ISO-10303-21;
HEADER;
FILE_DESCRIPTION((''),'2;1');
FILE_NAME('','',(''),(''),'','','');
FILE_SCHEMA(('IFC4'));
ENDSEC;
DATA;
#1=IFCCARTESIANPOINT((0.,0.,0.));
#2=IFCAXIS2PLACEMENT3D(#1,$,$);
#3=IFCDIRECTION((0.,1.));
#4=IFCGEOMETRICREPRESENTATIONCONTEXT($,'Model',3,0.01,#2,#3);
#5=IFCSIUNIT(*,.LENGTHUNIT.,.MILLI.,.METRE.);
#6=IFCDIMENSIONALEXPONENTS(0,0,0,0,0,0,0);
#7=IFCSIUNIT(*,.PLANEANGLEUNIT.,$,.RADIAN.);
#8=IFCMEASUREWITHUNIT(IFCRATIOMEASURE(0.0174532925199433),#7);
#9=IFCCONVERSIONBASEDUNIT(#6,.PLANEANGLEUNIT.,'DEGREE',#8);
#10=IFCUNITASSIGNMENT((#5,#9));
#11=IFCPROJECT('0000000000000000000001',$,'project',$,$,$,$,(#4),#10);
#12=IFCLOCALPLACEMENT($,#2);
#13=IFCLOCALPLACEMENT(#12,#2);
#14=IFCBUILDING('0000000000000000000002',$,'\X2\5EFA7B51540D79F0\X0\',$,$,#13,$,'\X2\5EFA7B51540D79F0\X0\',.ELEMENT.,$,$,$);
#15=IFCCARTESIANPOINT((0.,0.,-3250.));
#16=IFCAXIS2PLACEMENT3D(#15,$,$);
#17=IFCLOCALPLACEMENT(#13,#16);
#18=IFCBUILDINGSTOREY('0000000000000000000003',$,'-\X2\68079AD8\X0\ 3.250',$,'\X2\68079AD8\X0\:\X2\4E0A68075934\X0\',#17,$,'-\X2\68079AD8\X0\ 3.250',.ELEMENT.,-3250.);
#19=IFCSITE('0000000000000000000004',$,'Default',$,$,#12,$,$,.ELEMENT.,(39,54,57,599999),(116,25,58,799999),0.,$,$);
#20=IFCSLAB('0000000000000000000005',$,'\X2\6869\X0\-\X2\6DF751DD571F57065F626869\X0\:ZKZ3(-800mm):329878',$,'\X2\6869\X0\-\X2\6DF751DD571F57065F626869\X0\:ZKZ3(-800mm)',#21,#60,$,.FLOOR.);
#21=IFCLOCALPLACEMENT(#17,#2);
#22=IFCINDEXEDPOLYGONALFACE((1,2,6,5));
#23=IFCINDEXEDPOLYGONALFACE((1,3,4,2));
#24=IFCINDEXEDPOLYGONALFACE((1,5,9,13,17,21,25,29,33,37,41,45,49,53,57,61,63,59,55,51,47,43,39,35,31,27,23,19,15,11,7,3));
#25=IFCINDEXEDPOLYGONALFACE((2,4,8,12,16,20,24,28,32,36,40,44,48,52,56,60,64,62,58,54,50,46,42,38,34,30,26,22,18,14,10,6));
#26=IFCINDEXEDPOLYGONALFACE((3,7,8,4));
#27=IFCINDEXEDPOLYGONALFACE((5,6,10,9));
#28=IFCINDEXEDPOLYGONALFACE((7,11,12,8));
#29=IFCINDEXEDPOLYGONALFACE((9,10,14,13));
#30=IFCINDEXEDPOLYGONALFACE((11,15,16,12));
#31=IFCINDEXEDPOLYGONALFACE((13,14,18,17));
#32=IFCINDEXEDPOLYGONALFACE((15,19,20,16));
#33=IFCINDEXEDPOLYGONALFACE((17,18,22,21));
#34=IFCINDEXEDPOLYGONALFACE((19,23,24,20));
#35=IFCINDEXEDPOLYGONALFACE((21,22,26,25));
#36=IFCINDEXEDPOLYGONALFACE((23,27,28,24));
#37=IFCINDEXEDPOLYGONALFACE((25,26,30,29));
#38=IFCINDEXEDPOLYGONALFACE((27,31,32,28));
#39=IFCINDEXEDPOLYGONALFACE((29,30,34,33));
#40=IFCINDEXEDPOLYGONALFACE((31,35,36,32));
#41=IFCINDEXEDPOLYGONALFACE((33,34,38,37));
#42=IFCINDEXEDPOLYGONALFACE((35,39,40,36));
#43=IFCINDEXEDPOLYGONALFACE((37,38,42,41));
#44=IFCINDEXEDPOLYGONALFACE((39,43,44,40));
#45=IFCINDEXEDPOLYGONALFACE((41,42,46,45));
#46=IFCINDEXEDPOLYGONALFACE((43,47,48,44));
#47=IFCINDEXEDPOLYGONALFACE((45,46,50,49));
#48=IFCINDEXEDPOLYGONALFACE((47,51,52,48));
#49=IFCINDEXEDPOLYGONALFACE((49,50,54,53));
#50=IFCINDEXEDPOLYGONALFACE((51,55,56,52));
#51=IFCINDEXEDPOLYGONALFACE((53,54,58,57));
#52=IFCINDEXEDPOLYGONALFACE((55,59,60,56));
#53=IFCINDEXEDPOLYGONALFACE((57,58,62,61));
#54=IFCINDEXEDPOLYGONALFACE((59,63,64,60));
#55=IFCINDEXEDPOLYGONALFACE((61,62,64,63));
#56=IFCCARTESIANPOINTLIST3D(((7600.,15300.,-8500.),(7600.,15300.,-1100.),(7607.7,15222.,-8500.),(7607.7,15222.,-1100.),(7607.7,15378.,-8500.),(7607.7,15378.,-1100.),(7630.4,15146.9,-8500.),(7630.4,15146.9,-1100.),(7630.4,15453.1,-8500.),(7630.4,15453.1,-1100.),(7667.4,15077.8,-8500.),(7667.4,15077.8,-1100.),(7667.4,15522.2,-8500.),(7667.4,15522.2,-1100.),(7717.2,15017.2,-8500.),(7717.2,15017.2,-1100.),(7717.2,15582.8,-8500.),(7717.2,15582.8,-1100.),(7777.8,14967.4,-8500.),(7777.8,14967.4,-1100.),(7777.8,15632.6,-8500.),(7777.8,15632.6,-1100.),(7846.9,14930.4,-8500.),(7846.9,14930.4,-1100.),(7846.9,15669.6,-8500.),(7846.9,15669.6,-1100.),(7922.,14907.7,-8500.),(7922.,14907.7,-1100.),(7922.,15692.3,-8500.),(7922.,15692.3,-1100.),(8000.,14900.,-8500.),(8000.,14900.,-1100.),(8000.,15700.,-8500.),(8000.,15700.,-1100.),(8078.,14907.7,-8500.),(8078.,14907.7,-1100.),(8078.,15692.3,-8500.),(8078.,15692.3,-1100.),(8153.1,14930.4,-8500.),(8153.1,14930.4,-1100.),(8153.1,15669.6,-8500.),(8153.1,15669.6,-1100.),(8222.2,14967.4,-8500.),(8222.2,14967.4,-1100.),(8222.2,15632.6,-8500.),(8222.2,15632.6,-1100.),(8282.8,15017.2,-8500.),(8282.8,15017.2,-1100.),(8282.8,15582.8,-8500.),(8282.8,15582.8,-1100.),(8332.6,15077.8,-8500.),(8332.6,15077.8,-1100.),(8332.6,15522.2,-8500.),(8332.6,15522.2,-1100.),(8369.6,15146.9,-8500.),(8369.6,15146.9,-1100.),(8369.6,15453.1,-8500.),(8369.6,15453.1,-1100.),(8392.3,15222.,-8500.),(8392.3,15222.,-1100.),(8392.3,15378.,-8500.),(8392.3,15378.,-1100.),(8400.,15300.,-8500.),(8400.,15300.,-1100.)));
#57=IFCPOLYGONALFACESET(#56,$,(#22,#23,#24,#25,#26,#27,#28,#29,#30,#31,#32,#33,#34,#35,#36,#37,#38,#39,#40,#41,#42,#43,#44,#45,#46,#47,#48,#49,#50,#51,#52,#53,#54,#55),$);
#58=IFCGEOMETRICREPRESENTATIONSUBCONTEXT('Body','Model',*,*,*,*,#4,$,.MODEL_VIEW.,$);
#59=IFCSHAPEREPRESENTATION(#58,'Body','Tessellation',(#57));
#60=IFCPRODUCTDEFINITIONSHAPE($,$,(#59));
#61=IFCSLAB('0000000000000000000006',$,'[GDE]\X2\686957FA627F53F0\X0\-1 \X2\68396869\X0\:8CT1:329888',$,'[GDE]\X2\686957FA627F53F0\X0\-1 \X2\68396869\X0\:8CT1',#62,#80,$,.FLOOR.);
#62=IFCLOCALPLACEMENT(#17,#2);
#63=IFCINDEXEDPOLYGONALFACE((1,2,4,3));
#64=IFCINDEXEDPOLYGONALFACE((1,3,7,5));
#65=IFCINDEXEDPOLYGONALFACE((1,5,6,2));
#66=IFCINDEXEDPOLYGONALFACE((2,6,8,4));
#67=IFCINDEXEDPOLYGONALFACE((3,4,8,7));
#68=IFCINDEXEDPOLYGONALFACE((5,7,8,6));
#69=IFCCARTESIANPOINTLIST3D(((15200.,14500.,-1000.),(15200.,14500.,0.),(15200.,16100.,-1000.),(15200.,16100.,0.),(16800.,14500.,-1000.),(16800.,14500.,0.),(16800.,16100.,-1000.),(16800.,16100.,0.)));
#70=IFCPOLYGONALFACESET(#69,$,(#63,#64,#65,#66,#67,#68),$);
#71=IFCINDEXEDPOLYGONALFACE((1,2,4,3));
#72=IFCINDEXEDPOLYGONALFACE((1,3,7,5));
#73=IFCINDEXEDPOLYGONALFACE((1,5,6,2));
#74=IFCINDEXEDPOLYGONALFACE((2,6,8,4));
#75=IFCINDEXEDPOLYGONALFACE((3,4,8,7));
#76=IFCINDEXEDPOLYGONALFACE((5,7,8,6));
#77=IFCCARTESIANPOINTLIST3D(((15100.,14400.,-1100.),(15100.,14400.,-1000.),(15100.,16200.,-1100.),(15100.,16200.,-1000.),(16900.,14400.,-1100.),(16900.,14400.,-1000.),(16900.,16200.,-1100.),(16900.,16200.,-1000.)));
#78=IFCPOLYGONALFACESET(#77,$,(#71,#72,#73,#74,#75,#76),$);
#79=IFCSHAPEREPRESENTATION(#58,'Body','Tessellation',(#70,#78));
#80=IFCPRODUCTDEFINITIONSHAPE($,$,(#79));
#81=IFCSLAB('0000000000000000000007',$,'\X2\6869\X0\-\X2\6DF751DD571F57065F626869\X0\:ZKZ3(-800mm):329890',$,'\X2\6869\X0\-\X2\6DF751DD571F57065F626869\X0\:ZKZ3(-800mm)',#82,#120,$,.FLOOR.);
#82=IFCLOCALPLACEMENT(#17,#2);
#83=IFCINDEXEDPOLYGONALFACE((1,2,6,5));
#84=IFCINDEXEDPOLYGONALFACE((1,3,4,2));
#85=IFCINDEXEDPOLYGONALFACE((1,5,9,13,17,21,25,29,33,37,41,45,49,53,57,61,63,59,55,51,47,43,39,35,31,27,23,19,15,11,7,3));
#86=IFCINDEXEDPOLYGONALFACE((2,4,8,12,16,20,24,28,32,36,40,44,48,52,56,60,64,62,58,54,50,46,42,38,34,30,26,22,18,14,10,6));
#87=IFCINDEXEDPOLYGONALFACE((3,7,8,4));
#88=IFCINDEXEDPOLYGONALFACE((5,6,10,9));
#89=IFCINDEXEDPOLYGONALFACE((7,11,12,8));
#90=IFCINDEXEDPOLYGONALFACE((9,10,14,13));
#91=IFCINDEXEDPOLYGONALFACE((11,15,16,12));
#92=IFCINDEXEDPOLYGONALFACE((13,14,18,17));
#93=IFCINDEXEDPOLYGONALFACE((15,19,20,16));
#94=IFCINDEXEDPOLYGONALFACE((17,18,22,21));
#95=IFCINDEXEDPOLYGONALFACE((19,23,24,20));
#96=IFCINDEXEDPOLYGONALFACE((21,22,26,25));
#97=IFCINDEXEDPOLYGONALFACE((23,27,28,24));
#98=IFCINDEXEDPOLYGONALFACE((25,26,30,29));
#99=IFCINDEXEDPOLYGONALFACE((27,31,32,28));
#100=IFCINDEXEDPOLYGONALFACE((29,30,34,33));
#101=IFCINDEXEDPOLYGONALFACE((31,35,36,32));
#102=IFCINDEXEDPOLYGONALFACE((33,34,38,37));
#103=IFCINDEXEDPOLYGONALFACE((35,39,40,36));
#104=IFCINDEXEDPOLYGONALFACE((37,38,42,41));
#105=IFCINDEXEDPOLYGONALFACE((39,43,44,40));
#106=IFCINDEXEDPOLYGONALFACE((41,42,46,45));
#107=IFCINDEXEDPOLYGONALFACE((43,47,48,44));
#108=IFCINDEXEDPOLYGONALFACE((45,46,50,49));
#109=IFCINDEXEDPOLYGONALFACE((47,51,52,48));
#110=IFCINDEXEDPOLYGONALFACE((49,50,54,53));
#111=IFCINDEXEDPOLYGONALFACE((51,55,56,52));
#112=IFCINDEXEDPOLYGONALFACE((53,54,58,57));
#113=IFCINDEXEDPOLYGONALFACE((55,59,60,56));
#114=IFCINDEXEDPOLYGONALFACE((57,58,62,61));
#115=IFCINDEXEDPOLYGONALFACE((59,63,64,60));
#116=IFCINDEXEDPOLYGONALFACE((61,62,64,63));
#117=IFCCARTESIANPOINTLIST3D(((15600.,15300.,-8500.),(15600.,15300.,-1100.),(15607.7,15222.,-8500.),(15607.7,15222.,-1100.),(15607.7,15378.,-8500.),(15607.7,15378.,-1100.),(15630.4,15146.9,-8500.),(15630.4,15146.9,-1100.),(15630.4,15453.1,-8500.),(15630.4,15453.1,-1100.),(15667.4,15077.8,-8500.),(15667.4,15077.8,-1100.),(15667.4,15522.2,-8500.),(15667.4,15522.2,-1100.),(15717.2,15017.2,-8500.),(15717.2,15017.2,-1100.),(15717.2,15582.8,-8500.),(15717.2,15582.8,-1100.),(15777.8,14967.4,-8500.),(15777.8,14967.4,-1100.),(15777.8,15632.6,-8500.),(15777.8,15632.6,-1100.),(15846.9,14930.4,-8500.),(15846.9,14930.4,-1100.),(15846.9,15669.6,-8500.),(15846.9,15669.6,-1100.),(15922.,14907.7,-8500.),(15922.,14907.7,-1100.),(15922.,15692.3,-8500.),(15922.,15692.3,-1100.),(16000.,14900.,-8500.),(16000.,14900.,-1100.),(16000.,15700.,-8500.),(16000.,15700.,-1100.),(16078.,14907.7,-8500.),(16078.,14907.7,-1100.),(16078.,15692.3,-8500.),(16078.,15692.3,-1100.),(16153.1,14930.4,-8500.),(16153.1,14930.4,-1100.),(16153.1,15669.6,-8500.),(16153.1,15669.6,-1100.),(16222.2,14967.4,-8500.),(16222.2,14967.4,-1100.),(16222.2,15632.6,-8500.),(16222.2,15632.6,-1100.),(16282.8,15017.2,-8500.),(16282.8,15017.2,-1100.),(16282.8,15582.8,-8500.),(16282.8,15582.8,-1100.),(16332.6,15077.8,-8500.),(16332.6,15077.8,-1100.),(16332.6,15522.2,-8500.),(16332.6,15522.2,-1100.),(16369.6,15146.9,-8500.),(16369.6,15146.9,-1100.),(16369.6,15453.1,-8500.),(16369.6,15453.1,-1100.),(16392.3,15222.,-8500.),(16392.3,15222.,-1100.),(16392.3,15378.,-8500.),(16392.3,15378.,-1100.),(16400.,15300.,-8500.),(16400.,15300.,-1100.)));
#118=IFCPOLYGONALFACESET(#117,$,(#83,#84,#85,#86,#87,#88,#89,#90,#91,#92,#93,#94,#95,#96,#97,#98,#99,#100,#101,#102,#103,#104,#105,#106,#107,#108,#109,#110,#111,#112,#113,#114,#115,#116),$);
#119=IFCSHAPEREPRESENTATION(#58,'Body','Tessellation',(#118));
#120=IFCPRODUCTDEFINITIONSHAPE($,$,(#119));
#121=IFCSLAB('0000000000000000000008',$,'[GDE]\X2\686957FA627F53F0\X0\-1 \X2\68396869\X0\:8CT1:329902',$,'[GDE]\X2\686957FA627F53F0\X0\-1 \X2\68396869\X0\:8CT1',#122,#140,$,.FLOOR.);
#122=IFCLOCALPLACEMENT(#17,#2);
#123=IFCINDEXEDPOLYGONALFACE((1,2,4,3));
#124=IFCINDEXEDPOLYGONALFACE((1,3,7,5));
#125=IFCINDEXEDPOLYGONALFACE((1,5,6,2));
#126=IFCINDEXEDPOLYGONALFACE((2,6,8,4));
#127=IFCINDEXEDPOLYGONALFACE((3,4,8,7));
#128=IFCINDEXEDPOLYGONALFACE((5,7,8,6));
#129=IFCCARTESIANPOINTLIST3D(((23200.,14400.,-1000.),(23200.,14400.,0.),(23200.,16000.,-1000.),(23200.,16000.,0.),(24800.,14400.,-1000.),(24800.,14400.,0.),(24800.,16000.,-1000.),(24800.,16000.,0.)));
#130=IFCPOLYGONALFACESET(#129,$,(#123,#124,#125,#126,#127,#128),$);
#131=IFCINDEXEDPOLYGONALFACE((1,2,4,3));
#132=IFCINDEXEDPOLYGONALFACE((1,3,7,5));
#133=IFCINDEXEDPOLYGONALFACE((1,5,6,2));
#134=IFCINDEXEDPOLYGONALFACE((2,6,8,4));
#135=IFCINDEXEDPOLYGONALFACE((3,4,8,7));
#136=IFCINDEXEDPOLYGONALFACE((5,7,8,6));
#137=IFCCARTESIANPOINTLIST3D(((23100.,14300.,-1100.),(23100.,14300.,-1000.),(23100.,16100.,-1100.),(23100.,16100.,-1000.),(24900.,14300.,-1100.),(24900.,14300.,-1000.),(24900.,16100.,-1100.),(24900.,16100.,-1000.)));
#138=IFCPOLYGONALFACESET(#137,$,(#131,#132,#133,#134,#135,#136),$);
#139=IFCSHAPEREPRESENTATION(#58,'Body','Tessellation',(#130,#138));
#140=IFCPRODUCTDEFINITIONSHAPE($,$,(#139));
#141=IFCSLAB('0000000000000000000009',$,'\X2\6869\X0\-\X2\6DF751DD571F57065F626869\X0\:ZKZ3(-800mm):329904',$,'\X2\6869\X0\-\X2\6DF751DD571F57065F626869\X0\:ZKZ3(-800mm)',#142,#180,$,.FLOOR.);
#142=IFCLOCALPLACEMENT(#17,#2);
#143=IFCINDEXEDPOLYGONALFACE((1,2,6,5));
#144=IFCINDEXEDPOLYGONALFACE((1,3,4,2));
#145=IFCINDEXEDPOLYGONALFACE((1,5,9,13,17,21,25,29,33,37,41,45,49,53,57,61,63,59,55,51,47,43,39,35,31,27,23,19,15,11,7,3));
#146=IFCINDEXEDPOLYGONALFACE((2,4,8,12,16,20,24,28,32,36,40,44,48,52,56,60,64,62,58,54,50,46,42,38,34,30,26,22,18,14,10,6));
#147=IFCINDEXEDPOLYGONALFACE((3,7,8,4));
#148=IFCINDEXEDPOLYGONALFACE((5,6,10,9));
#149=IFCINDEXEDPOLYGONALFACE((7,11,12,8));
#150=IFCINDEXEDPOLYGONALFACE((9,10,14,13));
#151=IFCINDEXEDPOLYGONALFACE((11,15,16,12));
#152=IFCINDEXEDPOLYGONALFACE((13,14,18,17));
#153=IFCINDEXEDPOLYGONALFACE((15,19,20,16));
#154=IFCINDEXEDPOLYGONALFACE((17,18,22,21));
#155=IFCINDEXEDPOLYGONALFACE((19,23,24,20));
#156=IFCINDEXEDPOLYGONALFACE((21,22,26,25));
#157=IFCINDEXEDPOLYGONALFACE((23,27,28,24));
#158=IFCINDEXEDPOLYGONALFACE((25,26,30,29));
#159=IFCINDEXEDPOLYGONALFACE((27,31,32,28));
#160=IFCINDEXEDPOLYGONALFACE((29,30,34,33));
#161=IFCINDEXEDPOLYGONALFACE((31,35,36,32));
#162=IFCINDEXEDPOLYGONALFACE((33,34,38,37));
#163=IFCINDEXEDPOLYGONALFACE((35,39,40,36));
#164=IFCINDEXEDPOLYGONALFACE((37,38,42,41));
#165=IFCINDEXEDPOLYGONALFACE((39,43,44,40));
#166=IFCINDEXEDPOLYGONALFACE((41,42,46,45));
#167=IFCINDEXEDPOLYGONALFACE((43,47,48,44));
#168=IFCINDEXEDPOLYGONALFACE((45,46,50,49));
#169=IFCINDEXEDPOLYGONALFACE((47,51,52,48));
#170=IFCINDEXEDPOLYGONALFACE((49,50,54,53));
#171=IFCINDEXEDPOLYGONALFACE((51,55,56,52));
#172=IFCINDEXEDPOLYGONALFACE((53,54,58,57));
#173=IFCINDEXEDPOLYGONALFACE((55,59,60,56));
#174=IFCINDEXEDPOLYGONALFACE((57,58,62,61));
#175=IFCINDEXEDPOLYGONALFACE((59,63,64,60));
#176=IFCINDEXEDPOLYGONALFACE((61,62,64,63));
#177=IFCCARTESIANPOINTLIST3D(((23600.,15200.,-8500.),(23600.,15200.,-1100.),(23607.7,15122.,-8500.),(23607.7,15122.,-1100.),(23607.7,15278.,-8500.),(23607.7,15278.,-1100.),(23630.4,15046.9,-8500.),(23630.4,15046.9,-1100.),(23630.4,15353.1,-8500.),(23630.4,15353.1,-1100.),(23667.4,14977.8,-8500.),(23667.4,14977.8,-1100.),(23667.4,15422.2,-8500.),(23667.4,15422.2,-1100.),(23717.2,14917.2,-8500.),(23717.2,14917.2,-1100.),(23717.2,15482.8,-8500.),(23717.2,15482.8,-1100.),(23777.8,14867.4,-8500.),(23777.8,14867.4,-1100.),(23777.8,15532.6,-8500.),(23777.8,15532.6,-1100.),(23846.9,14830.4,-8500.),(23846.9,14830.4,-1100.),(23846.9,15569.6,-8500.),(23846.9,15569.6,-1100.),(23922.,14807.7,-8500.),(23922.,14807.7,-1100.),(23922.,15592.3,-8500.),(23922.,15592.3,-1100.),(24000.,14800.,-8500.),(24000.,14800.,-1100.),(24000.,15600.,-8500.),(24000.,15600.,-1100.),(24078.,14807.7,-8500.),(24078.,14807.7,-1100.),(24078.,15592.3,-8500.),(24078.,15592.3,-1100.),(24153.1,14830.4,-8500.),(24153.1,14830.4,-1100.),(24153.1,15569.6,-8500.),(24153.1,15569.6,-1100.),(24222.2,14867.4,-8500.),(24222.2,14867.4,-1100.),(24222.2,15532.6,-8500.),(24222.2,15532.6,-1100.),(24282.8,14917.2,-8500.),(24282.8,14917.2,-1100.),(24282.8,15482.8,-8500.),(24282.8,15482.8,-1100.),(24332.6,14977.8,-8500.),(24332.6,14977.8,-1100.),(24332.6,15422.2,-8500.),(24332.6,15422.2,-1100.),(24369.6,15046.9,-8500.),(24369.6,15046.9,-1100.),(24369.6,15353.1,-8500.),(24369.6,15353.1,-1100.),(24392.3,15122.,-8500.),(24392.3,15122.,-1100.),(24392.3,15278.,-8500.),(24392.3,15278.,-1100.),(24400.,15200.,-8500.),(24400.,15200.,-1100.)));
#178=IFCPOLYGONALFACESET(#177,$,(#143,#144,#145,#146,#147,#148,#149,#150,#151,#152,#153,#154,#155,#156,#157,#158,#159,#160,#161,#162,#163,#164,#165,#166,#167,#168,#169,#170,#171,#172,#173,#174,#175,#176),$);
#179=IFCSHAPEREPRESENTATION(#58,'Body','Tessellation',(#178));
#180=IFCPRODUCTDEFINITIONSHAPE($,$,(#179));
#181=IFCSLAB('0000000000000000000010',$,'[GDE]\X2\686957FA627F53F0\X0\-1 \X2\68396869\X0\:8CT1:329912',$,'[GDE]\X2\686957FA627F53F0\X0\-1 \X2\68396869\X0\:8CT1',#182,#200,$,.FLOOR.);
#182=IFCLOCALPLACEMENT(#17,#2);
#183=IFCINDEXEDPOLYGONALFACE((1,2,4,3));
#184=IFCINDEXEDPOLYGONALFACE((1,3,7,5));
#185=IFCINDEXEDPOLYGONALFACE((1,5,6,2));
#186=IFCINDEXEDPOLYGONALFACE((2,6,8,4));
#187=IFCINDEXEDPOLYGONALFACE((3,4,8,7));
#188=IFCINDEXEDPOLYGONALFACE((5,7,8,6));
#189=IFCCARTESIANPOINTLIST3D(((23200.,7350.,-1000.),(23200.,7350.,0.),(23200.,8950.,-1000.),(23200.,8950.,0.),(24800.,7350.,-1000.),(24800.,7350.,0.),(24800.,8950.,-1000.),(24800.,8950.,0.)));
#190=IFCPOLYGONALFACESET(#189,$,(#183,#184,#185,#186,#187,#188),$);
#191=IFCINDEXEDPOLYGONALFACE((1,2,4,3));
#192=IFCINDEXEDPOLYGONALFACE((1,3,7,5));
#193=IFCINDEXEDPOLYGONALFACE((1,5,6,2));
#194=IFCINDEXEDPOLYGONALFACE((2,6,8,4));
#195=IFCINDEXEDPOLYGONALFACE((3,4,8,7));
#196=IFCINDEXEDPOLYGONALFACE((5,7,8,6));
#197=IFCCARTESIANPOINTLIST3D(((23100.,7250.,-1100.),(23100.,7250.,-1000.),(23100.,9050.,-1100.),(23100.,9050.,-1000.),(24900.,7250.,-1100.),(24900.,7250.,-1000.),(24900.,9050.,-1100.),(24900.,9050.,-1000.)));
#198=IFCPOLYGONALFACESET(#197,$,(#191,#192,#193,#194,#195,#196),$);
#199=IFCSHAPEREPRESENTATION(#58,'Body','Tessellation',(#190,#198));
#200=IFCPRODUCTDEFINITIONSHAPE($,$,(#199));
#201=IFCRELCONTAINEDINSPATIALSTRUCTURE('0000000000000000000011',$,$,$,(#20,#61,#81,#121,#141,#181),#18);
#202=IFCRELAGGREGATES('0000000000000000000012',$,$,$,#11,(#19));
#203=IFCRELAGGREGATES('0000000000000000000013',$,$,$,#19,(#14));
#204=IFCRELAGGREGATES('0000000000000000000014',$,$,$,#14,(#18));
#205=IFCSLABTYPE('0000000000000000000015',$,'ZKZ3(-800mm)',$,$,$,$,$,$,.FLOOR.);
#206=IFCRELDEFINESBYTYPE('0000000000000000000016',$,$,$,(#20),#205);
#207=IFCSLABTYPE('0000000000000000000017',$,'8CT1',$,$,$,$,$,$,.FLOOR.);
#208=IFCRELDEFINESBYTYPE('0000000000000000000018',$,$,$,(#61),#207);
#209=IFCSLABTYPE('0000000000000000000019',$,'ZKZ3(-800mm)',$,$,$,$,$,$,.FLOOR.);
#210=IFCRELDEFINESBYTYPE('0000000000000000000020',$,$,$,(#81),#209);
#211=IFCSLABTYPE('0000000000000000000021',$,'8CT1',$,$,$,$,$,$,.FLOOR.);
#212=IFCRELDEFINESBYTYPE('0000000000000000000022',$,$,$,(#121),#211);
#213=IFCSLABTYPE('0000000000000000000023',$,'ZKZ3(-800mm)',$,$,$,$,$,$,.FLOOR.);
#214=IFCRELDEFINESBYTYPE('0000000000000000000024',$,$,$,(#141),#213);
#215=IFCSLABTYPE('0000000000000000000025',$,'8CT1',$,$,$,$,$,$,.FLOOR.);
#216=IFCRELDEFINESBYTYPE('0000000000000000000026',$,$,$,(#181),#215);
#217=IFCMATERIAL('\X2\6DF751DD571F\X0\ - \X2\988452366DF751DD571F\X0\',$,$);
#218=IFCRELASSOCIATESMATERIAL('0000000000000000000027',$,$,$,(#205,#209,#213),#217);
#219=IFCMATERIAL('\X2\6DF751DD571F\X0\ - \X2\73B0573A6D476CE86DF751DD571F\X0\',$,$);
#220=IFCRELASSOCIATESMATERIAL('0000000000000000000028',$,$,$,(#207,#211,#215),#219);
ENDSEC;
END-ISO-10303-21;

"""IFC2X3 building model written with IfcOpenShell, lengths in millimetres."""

from ifc_helpers import new_model, entity, si_unit, converted_unit, direction, frame, frame_2d, origin, origin_2d_with_axis, place, context, subcontext, project, spatial, rectangle, circle, extrude, material, type_object, element, save


model = new_model("IFC2X3")

# Units and contexts
model_context = context("Model", 3, precision=0.01, world=origin(), true_north=direction((0.0, 1.0)))
body_context = subcontext(model_context, "Body", "Model", "MODEL_VIEW")
ifc_project = project(units=[si_unit("LENGTHUNIT", "METRE", prefix="MILLI"), converted_unit("PLANEANGLEUNIT", "DEGREE", entity("IfcRatioMeasure", 0.0174532925199433), si_unit("PLANEANGLEUNIT", "RADIAN"), dimensions=[0, 0, 0, 0, 0, 0, 0])], contexts=[model_context])

# Site, building, storey
site_placement = place(None, origin())
site = spatial("IfcSite", under=ifc_project, at=site_placement, Name="Default", CompositionType="ELEMENT", RefLatitude=(39, 54, 57, 599999), RefLongitude=(116, 25, 58, 799999), RefElevation=0.0)
building_placement = place(site_placement, origin())
building = spatial("IfcBuilding", under=site, at=building_placement, Name="建筑名称", LongName="建筑名称", CompositionType="ELEMENT")
storey_placement = place(building_placement, frame((0.0, 0.0, -3250.0)))
storey = spatial("IfcBuildingStorey", under=building, at=storey_placement, Name="-标高 3.250", ObjectType="标高:上标头", LongName="-标高 3.250", CompositionType="ELEMENT", Elevation=-3250.0)

# Slabs
ifc_material_1 = material(Name="混凝土 - 现场浇注混凝土")
ifc_material_2 = material(Name="混凝土 - 预制混凝土")
slab_type_1 = type_object("IfcSlabType", Name="ZKZ3(-800mm)", PredefinedType="FLOOR", material=ifc_material_2)
slab_1_placement = place(storey_placement, origin())
element("IfcSlab", 1, at=slab_1_placement, inside=storey, type_object=slab_type_1, Name="桩-混凝土圆形桩:ZKZ3(-800mm):329878", ObjectType="桩-混凝土圆形桩:ZKZ3(-800mm)", PredefinedType="FLOOR", context=body_context, shape_type="SweptSolid", body=[
    extrude(circle(Radius=400.0, at=frame_2d((0.0, 0.0), x_axis=(1.0, 0.0))), frame((8000.0, 15300.0, -8500.0)), (0.0, 0.0, 1.0), 7400.0),
])
slab_type_2 = type_object("IfcSlabType", Name="8CT1", PredefinedType="FLOOR", material=ifc_material_1)
slab_2_placement = place(storey_placement, origin())
element("IfcSlab", 2, at=slab_2_placement, inside=storey, type_object=slab_type_2, Name="[GDE]桩基承台-1 根桩:8CT1:329888", ObjectType="[GDE]桩基承台-1 根桩:8CT1", PredefinedType="FLOOR", context=body_context, shape_type="SweptSolid", body=[
    extrude(rectangle(XDim=1600.0, YDim=1600.0, at=origin_2d_with_axis()), frame((16000.0, 15300.0, -1000.0), z_axis=(0.0, 0.0, 1.0), x_axis=(-1.0, 0.0, 0.0)), (0.0, 0.0, 1.0), 1000.0),
    extrude(rectangle(XDim=1800.0, YDim=1800.0, at=frame_2d((0.0, 0.0), x_axis=(1.0, 0.0))), frame((16000.0, 15300.0, -1100.0), z_axis=(0.0, 0.0, 1.0), x_axis=(-1.0, 0.0, 0.0)), (0.0, 0.0, 1.0), 100.0),
])
slab_type_3 = type_object("IfcSlabType", Name="ZKZ3(-800mm)", PredefinedType="FLOOR", material=ifc_material_2)
slab_3_placement = place(storey_placement, origin())
element("IfcSlab", 3, at=slab_3_placement, inside=storey, type_object=slab_type_3, Name="桩-混凝土圆形桩:ZKZ3(-800mm):329890", ObjectType="桩-混凝土圆形桩:ZKZ3(-800mm)", PredefinedType="FLOOR", context=body_context, shape_type="SweptSolid", body=[
    extrude(circle(Radius=400.0, at=frame_2d((0.0, 0.0), x_axis=(1.0, 0.0))), frame((16000.0, 15300.0, -8500.0)), (0.0, 0.0, 1.0), 7400.0),
])
slab_type_4 = type_object("IfcSlabType", Name="8CT1", PredefinedType="FLOOR", material=ifc_material_1)
slab_4_placement = place(storey_placement, origin())
element("IfcSlab", 4, at=slab_4_placement, inside=storey, type_object=slab_type_4, Name="[GDE]桩基承台-1 根桩:8CT1:329902", ObjectType="[GDE]桩基承台-1 根桩:8CT1", PredefinedType="FLOOR", context=body_context, shape_type="SweptSolid", body=[
    extrude(rectangle(XDim=1600.0, YDim=1600.0, at=origin_2d_with_axis()), frame((24000.0, 15200.0, -1000.0), z_axis=(0.0, 0.0, 1.0), x_axis=(-1.0, 0.0, 0.0)), (0.0, 0.0, 1.0), 1000.0),
    extrude(rectangle(XDim=1800.0, YDim=1800.0, at=frame_2d((0.0, 0.0), x_axis=(1.0, 0.0))), frame((24000.0, 15200.0, -1100.0), z_axis=(0.0, 0.0, 1.0), x_axis=(-1.0, 0.0, 0.0)), (0.0, 0.0, 1.0), 100.0),
])
slab_type_5 = type_object("IfcSlabType", Name="ZKZ3(-800mm)", PredefinedType="FLOOR", material=ifc_material_2)
slab_5_placement = place(storey_placement, origin())
element("IfcSlab", 5, at=slab_5_placement, inside=storey, type_object=slab_type_5, Name="桩-混凝土圆形桩:ZKZ3(-800mm):329904", ObjectType="桩-混凝土圆形桩:ZKZ3(-800mm)", PredefinedType="FLOOR", context=body_context, shape_type="SweptSolid", body=[
    extrude(circle(Radius=400.0, at=frame_2d((0.0, 0.0), x_axis=(1.0, 0.0))), frame((24000.0, 15200.0, -8500.0)), (0.0, 0.0, 1.0), 7400.0),
])
slab_type_6 = type_object("IfcSlabType", Name="8CT1", PredefinedType="FLOOR", material=ifc_material_1)
slab_6_placement = place(storey_placement, origin())
element("IfcSlab", 6, at=slab_6_placement, inside=storey, type_object=slab_type_6, Name="[GDE]桩基承台-1 根桩:8CT1:329912", ObjectType="[GDE]桩基承台-1 根桩:8CT1", PredefinedType="FLOOR", context=body_context, shape_type="SweptSolid", body=[
    extrude(rectangle(XDim=1600.0, YDim=1600.0, at=origin_2d_with_axis()), frame((24000.0, 8150.0, -1000.0), z_axis=(0.0, 0.0, 1.0), x_axis=(-1.0, 0.0, 0.0)), (0.0, 0.0, 1.0), 1000.0),
    extrude(rectangle(XDim=1800.0, YDim=1800.0, at=origin_2d_with_axis()), frame((24000.0, 8150.0, -1100.0), z_axis=(0.0, 0.0, 1.0), x_axis=(-1.0, 0.0, 0.0)), (0.0, 0.0, 1.0), 100.0),
])

save(model, "model.ifc")
